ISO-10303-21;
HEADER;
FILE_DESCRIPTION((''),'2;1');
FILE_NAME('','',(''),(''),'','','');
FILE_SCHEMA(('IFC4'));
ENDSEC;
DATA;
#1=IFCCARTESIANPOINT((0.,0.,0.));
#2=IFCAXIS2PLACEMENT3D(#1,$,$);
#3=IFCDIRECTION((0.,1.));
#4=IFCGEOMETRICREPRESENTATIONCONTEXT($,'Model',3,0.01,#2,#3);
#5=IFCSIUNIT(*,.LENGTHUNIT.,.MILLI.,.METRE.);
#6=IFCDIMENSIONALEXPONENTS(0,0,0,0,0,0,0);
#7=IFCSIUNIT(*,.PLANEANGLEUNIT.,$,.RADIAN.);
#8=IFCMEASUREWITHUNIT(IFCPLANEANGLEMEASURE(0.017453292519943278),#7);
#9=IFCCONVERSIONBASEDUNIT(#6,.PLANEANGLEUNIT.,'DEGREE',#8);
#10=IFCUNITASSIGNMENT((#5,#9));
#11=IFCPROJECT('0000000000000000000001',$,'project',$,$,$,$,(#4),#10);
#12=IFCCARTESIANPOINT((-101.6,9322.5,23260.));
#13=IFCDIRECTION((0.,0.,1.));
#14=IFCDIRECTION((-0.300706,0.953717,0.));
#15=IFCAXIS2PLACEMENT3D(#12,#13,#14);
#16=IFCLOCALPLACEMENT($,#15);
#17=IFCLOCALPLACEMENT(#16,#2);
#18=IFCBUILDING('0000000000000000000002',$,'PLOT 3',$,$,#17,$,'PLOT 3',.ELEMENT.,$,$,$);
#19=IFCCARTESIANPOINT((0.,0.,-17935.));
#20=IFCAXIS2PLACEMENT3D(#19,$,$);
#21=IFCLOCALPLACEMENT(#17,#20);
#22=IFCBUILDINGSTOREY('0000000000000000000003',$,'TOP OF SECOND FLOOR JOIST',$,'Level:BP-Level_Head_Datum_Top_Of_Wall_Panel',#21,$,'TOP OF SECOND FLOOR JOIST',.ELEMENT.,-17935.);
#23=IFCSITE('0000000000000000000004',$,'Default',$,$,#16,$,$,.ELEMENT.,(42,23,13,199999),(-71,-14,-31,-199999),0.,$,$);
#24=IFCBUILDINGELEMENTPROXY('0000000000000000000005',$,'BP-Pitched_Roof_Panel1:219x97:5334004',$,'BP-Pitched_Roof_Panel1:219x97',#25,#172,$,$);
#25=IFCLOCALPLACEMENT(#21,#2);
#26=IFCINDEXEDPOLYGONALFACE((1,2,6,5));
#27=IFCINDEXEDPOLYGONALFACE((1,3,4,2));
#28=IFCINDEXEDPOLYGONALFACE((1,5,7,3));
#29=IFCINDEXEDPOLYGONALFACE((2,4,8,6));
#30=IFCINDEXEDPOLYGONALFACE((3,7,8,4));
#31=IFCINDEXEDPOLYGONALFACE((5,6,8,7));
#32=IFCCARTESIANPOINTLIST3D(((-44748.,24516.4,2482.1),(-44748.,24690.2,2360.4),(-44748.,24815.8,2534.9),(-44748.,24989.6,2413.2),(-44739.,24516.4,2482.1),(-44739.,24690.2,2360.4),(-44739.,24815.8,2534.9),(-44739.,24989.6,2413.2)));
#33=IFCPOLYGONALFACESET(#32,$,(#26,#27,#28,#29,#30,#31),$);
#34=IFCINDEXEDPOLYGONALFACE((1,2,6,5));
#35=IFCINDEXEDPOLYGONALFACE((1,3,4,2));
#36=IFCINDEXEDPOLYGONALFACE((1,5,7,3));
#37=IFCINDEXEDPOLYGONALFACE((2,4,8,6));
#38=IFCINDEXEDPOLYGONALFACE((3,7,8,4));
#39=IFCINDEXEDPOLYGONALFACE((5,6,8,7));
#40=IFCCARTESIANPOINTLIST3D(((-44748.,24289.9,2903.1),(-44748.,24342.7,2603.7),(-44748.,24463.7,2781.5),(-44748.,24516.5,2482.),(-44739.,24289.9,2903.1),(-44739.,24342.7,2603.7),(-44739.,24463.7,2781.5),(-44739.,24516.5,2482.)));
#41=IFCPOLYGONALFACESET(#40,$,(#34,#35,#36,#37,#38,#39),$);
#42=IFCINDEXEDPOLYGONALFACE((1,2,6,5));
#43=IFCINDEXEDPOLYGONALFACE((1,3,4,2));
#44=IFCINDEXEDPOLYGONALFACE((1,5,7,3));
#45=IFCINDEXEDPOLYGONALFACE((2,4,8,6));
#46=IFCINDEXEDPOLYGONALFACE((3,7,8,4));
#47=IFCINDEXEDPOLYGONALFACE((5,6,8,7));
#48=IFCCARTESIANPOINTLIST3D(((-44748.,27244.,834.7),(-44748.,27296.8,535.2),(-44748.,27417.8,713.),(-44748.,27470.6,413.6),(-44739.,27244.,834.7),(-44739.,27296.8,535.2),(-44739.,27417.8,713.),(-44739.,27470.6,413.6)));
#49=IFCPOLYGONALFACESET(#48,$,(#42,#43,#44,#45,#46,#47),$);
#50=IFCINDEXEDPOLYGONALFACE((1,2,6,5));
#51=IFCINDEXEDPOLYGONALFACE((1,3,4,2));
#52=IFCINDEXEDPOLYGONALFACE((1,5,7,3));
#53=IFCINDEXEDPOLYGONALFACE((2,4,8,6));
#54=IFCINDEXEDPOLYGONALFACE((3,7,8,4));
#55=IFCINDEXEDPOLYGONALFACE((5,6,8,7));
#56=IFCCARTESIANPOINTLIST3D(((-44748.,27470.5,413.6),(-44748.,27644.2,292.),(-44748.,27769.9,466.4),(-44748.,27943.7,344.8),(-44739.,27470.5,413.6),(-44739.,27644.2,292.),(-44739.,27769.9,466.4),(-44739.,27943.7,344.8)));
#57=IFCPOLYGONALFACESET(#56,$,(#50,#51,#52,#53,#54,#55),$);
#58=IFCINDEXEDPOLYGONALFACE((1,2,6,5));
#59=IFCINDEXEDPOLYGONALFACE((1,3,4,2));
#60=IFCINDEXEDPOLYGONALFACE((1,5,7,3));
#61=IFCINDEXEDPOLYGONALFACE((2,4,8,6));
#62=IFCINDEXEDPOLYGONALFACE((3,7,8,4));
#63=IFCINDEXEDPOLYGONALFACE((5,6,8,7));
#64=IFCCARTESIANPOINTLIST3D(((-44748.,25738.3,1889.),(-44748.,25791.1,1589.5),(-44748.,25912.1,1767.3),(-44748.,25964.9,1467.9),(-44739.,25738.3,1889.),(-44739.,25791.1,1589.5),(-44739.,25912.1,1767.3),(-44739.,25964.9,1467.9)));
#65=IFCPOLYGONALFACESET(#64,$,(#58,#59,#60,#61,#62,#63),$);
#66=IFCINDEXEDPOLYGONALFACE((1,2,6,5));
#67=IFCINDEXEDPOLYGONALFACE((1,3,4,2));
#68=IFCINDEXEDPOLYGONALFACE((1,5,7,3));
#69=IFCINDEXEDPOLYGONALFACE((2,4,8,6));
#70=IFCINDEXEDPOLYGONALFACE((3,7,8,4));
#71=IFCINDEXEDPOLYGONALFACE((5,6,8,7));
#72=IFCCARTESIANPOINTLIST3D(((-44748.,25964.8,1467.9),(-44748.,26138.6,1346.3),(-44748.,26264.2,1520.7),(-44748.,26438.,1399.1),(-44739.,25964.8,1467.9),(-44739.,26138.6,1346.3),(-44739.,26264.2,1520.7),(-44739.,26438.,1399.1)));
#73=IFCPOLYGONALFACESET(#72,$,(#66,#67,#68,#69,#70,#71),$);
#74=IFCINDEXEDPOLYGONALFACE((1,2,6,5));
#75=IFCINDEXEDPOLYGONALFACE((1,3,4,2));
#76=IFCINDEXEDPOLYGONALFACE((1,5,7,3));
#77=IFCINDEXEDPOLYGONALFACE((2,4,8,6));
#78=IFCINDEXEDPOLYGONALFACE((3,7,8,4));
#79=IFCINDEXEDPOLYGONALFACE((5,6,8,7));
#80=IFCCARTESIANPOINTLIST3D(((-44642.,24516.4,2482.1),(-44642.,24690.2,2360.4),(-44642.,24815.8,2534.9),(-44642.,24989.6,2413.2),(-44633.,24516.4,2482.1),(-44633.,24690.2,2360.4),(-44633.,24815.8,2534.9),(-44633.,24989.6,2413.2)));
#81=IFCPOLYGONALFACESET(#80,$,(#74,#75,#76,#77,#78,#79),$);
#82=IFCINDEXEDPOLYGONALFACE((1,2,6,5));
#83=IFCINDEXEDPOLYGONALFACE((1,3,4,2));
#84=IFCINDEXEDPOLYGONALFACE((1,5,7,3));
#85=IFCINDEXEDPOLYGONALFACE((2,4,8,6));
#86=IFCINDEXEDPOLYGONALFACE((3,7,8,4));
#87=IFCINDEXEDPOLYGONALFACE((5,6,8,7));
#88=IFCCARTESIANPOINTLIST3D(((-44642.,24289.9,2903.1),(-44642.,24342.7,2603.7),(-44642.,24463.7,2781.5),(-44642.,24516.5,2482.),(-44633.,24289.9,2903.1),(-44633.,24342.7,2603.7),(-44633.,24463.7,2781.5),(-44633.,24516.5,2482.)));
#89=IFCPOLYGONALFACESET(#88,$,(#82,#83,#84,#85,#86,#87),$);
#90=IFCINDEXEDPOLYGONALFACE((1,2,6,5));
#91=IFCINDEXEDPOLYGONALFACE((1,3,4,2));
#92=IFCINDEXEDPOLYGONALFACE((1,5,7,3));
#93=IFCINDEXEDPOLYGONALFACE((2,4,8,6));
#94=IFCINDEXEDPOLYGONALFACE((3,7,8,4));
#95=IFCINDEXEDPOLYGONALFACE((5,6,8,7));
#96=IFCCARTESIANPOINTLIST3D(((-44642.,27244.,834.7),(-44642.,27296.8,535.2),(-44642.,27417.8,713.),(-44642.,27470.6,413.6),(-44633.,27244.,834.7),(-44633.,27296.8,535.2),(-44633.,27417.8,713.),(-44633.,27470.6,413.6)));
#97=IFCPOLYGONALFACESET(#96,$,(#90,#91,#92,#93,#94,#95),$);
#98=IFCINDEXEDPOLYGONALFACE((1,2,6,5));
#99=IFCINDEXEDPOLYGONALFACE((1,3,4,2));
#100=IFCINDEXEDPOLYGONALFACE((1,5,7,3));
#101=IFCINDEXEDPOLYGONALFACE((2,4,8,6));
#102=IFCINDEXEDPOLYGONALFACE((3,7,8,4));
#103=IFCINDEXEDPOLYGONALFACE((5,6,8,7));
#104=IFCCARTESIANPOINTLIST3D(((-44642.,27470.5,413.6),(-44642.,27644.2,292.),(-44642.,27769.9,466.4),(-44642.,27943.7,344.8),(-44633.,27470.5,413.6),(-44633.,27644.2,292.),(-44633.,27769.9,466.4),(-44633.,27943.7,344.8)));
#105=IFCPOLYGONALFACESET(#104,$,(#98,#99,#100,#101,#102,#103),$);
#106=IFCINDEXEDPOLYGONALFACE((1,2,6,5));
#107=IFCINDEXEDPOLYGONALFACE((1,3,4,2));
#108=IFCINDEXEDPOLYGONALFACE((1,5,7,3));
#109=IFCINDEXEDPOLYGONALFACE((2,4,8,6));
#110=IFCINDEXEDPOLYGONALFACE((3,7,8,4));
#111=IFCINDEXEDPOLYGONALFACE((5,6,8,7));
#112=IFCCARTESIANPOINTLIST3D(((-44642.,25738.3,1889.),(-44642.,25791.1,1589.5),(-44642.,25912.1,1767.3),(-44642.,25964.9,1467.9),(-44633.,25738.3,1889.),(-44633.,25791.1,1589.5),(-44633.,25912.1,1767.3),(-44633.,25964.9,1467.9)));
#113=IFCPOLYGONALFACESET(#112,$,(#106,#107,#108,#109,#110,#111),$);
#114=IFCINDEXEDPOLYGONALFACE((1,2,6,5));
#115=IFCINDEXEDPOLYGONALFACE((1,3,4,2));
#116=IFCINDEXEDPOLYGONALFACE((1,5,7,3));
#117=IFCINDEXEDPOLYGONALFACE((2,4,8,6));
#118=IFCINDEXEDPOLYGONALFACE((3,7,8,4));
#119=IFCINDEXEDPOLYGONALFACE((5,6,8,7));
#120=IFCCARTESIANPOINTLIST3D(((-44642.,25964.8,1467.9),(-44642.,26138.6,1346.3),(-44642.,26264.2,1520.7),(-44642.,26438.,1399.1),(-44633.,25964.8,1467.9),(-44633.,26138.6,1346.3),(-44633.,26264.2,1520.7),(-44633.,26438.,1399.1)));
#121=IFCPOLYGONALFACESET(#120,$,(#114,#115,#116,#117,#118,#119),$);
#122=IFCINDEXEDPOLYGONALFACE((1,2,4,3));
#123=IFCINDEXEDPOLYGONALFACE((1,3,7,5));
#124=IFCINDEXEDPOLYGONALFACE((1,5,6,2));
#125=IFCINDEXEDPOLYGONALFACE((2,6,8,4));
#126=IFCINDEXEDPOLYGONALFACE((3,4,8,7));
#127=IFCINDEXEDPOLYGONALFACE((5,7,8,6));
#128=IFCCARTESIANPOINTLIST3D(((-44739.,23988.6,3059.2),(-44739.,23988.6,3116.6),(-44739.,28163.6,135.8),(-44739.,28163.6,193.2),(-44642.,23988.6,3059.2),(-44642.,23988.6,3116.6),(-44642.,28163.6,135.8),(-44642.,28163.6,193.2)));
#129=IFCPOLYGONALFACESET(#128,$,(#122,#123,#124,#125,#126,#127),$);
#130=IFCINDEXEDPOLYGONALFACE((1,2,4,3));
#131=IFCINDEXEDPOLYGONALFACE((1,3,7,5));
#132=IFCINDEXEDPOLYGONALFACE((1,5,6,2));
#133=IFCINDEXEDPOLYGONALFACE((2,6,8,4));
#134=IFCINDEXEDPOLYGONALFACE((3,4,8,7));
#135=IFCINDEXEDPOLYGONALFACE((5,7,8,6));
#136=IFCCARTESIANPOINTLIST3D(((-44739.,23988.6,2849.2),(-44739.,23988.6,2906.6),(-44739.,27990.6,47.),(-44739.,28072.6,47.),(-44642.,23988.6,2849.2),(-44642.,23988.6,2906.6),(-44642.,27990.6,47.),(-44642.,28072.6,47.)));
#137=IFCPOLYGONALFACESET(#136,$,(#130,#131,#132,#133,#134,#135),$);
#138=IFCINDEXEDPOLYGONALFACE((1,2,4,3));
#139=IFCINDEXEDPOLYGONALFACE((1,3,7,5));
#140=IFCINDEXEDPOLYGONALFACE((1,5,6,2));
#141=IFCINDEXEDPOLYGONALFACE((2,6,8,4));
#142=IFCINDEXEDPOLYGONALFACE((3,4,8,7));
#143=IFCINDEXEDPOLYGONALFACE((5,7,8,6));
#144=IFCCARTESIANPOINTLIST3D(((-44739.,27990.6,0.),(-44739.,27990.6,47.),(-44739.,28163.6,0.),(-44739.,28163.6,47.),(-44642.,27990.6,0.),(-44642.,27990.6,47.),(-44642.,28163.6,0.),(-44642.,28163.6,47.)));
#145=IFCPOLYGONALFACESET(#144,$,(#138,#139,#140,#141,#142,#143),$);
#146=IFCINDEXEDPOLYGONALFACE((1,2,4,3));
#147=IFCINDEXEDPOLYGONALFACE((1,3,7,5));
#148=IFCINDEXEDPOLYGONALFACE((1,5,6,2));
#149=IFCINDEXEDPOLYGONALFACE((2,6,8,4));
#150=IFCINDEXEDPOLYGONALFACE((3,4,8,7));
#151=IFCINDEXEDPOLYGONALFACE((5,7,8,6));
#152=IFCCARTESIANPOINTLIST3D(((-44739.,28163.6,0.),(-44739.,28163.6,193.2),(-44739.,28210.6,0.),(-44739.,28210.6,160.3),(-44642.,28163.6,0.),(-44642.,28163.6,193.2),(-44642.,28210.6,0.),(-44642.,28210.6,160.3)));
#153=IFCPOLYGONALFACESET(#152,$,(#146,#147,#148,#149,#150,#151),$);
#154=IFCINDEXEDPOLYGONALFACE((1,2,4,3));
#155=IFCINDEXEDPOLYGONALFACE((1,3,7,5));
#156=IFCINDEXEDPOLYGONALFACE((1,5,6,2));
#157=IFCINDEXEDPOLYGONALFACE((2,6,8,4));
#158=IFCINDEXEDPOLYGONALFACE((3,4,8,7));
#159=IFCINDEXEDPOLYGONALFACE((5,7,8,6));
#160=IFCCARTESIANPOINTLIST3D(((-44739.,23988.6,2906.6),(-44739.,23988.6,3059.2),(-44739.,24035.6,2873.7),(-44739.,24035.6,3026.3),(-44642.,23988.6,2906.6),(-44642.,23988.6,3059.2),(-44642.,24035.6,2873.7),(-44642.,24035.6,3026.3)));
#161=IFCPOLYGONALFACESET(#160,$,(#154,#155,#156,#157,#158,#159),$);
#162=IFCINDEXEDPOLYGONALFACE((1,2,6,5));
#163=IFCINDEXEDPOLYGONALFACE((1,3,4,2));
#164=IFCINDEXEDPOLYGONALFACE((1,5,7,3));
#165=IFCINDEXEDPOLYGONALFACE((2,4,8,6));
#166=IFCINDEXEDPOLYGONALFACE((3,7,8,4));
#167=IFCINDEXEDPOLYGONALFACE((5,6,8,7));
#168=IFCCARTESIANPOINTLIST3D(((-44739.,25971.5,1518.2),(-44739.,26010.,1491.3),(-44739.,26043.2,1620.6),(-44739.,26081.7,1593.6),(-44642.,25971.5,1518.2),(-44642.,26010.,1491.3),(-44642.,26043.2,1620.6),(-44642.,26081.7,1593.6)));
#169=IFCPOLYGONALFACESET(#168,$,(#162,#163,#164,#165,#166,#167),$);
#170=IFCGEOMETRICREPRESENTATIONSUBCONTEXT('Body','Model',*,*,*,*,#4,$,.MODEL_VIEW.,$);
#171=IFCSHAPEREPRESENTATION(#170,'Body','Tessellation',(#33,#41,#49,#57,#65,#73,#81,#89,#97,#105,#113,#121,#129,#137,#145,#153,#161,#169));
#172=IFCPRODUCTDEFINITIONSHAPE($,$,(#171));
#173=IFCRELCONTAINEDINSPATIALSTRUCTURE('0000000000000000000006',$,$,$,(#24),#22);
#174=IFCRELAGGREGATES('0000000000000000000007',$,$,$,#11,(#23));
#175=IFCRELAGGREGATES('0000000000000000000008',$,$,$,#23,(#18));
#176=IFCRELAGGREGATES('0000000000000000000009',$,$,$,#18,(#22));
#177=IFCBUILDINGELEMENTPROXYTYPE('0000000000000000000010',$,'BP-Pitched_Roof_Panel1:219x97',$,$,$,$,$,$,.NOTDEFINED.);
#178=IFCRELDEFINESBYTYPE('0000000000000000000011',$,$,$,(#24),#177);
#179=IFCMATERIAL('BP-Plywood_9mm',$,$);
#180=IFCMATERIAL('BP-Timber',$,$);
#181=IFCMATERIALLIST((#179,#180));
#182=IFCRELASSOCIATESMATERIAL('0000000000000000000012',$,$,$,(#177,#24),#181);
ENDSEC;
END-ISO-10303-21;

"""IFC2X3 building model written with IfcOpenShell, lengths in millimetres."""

from ifc_helpers import new_model, entity, si_unit, converted_unit, direction, frame, frame_2d, origin, origin_2d_with_axis, place, context, subcontext, project, spatial, polyline, rectangle, outline, extrude, source, transform, mapped, material, material_list, type_object, type_shapes, element, save


model = new_model("IFC2X3")

# Units and contexts
model_context = context("Model", 3, precision=0.01, world=origin(), true_north=direction((0.0, 1.0)))
body_context = subcontext(model_context, "Body", "Model", "MODEL_VIEW")
ifc_project = project(units=[si_unit("LENGTHUNIT", "METRE", prefix="MILLI"), converted_unit("PLANEANGLEUNIT", "DEGREE", entity("IfcPlaneAngleMeasure", 0.017453292519943278), si_unit("PLANEANGLEUNIT", "RADIAN"), dimensions=[0, 0, 0, 0, 0, 0, 0])], contexts=[model_context])

# Site, building, storey
site_placement = place(None, frame((-101.6, 9322.5, 23260.0), z_axis=(0.0, 0.0, 1.0), x_axis=(-0.300706, 0.953717, 0.0)))
site = spatial("IfcSite", under=ifc_project, at=site_placement, Name="Default", CompositionType="ELEMENT", RefLatitude=(42, 23, 13, 199999), RefLongitude=(-71, -14, -31, -199999), RefElevation=0.0)
building_placement = place(site_placement, origin())
building = spatial("IfcBuilding", under=site, at=building_placement, Name="PLOT 3", LongName="PLOT 3", CompositionType="ELEMENT")
storey_placement = place(building_placement, frame((0.0, 0.0, -17935.0)))
storey = spatial("IfcBuildingStorey", under=building, at=storey_placement, Name="TOP OF SECOND FLOOR JOIST", ObjectType="Level:BP-Level_Head_Datum_Top_Of_Wall_Panel", LongName="TOP OF SECOND FLOOR JOIST", CompositionType="ELEMENT", Elevation=-17935.0)

# Building element proxy
ifc_material_1 = material(Name="BP-Timber")
ifc_material_2 = material(Name="BP-Plywood_9mm")
ifc_material_list = material_list([ifc_material_2, ifc_material_1])
building_element_proxy_type_1 = type_object("IfcBuildingElementProxyType", Name="BP-Pitched_Roof_Panel1:219x97", PredefinedType="NOTDEFINED", material=ifc_material_list)
shared_shape_1 = source(origin(), body_context, "Body", "SweptSolid", [
    extrude(outline(polyline([(-77.0, -75.0), (227.0, -75.0), (77.0, 75.0), (-227.0, 75.0), (-77.0, -75.0)])), frame((35.3, -3956.0, 2447.7), z_axis=(0.0, 1.0, 0.0), x_axis=(-0.984808, 0.0, 0.173648)), (0.0, 0.0, 1.0), 9.0),
    extrude(outline(polyline([(1.4, -107.5), (213.6, -107.5), (-1.4, 107.5), (-213.6, 107.5), (1.4, -107.5)])), frame((385.1, -3956.0, 2692.6), z_axis=(0.0, 1.0, 0.0), x_axis=(-0.819152, 0.0, -0.573576)), (0.0, 0.0, 1.0), 9.0),
    extrude(outline(polyline([(1.4, -107.5), (213.6, -107.5), (-1.4, 107.5), (-213.6, 107.5), (1.4, -107.5)])), frame((-2569.0, -3956.0, 624.1), z_axis=(0.0, 1.0, 0.0), x_axis=(-0.819152, 0.0, -0.573576)), (0.0, 0.0, 1.0), 9.0),
    extrude(outline(polyline([(-77.0, -75.0), (227.0, -75.0), (77.0, 75.0), (-227.0, 75.0), (-77.0, -75.0)])), frame((-2918.8, -3956.0, 379.2), z_axis=(0.0, 1.0, 0.0), x_axis=(-0.984808, 0.0, 0.173648)), (0.0, 0.0, 1.0), 9.0),
    extrude(outline(polyline([(1.4, -107.5), (213.6, -107.5), (-1.4, 107.5), (-213.6, 107.5), (1.4, -107.5)])), frame((-1063.3, -3956.0, 1678.4), z_axis=(0.0, 1.0, 0.0), x_axis=(-0.819152, 0.0, -0.573576)), (0.0, 0.0, 1.0), 9.0),
    extrude(outline(polyline([(-77.0, -75.0), (227.0, -75.0), (77.0, 75.0), (-227.0, 75.0), (-77.0, -75.0)])), frame((-1413.1, -3956.0, 1433.5), z_axis=(0.0, 1.0, 0.0), x_axis=(-0.984808, 0.0, 0.173648)), (0.0, 0.0, 1.0), 9.0),
    extrude(outline(polyline([(-77.0, -75.0), (227.0, -75.0), (77.0, 75.0), (-227.0, 75.0), (-77.0, -75.0)])), frame((35.3, -3850.0, 2447.7), z_axis=(0.0, 1.0, 0.0), x_axis=(-0.984808, 0.0, 0.173648)), (0.0, 0.0, 1.0), 9.0),
    extrude(outline(polyline([(1.4, -107.5), (213.6, -107.5), (-1.4, 107.5), (-213.6, 107.5), (1.4, -107.5)])), frame((385.1, -3850.0, 2692.6), z_axis=(0.0, 1.0, 0.0), x_axis=(-0.819152, 0.0, -0.573576)), (0.0, 0.0, 1.0), 9.0),
    extrude(outline(polyline([(1.4, -107.5), (213.6, -107.5), (-1.4, 107.5), (-213.6, 107.5), (1.4, -107.5)])), frame((-2569.0, -3850.0, 624.1), z_axis=(0.0, 1.0, 0.0), x_axis=(-0.819152, 0.0, -0.573576)), (0.0, 0.0, 1.0), 9.0),
    extrude(outline(polyline([(-77.0, -75.0), (227.0, -75.0), (77.0, 75.0), (-227.0, 75.0), (-77.0, -75.0)])), frame((-2918.8, -3850.0, 379.2), z_axis=(0.0, 1.0, 0.0), x_axis=(-0.984808, 0.0, 0.173648)), (0.0, 0.0, 1.0), 9.0),
    extrude(outline(polyline([(1.4, -107.5), (213.6, -107.5), (-1.4, 107.5), (-213.6, 107.5), (1.4, -107.5)])), frame((-1063.3, -3850.0, 1678.4), z_axis=(0.0, 1.0, 0.0), x_axis=(-0.819152, 0.0, -0.573576)), (0.0, 0.0, 1.0), 9.0),
    extrude(outline(polyline([(-77.0, -75.0), (227.0, -75.0), (77.0, 75.0), (-227.0, 75.0), (-77.0, -75.0)])), frame((-1413.1, -3850.0, 1433.5), z_axis=(0.0, 1.0, 0.0), x_axis=(-0.984808, 0.0, 0.173648)), (0.0, 0.0, 1.0), 9.0),
    extrude(outline(polyline([(-1490.4, -2087.5), (-1433.0, -2087.5), (1490.4, 2087.5), (1433.0, 2087.5), (-1490.4, -2087.5)])), frame((-1287.8, -3947.0, 1626.2), z_axis=(0.0, 1.0, 0.0), x_axis=(0.0, 0.0, -1.0)), (0.0, 0.0, 1.0), 97.0),
    extrude(outline(polyline([(-1444.1, -2021.5), (-1386.8, -2021.5), (1415.5, 1980.5), (1415.5, 2062.5), (-1444.1, -2021.5)])), frame((-1221.8, -3947.0, 1462.5), z_axis=(0.0, 1.0, 0.0), x_axis=(0.0, 0.0, -1.0)), (0.0, 0.0, 1.0), 97.0),
    extrude(rectangle(XDim=173.0, YDim=97.0, at=origin_2d_with_axis()), frame((-3288.8, -3898.5, 0.0), z_axis=(0.0, 0.0, 1.0), x_axis=(-1.0, 0.0, 0.0)), (0.0, 0.0, 1.0), 47.0),
    extrude(outline(polyline([(22.0, -72.4), (79.4, -72.4), (-31.4, 85.9), (-69.9, 58.9), (22.0, -72.4)])), frame((-3398.8, -3947.0, 88.4), z_axis=(0.0, 1.0, 0.0), x_axis=(0.819152, 0.0, 0.573576)), (0.0, 0.0, 1.0), 97.0),
    extrude(outline(polyline([(15.1, -62.5), (72.5, -62.5), (-15.1, 62.5), (-72.5, 62.5), (15.1, -62.5)])), frame((776.2, -3947.0, 2966.5), z_axis=(0.0, 1.0, 0.0), x_axis=(0.819152, 0.0, 0.573576)), (0.0, 0.0, 1.0), 97.0),
    extrude(rectangle(XDim=47.0, YDim=97.0, at=frame_2d((0.0, 0.0), x_axis=(1.0, 0.0))), frame((-1202.4, -3898.5, 1504.7), z_axis=(-0.573576, 0.0, 0.819152), x_axis=(-0.819152, 0.0, -0.573576)), (0.0, 0.0, 1.0), 125.0),
])
type_shapes(building_element_proxy_type_1, [shared_shape_1])
for number, where, z_axis, x_axis, name in (
    (1, (-40792.0, 24788.3, 0.0), (0.0, 0.0, 1.0), (0.0, -1.0, 0.0), "BP-Pitched_Roof_Panel1:219x97:5334004"),
):
    element("IfcBuildingElementProxy", number, at=place(storey_placement, frame(where, z_axis=z_axis, x_axis=x_axis)), inside=storey, type_object=building_element_proxy_type_1, material=ifc_material_list, Name=name, ObjectType="BP-Pitched_Roof_Panel1:219x97", context=body_context, shape_type="MappedRepresentation", body=[
        mapped(shared_shape_1, transform((0.0, 0.0, 0.0), scale=1.0)),
    ])

save(model, "model.ifc")
